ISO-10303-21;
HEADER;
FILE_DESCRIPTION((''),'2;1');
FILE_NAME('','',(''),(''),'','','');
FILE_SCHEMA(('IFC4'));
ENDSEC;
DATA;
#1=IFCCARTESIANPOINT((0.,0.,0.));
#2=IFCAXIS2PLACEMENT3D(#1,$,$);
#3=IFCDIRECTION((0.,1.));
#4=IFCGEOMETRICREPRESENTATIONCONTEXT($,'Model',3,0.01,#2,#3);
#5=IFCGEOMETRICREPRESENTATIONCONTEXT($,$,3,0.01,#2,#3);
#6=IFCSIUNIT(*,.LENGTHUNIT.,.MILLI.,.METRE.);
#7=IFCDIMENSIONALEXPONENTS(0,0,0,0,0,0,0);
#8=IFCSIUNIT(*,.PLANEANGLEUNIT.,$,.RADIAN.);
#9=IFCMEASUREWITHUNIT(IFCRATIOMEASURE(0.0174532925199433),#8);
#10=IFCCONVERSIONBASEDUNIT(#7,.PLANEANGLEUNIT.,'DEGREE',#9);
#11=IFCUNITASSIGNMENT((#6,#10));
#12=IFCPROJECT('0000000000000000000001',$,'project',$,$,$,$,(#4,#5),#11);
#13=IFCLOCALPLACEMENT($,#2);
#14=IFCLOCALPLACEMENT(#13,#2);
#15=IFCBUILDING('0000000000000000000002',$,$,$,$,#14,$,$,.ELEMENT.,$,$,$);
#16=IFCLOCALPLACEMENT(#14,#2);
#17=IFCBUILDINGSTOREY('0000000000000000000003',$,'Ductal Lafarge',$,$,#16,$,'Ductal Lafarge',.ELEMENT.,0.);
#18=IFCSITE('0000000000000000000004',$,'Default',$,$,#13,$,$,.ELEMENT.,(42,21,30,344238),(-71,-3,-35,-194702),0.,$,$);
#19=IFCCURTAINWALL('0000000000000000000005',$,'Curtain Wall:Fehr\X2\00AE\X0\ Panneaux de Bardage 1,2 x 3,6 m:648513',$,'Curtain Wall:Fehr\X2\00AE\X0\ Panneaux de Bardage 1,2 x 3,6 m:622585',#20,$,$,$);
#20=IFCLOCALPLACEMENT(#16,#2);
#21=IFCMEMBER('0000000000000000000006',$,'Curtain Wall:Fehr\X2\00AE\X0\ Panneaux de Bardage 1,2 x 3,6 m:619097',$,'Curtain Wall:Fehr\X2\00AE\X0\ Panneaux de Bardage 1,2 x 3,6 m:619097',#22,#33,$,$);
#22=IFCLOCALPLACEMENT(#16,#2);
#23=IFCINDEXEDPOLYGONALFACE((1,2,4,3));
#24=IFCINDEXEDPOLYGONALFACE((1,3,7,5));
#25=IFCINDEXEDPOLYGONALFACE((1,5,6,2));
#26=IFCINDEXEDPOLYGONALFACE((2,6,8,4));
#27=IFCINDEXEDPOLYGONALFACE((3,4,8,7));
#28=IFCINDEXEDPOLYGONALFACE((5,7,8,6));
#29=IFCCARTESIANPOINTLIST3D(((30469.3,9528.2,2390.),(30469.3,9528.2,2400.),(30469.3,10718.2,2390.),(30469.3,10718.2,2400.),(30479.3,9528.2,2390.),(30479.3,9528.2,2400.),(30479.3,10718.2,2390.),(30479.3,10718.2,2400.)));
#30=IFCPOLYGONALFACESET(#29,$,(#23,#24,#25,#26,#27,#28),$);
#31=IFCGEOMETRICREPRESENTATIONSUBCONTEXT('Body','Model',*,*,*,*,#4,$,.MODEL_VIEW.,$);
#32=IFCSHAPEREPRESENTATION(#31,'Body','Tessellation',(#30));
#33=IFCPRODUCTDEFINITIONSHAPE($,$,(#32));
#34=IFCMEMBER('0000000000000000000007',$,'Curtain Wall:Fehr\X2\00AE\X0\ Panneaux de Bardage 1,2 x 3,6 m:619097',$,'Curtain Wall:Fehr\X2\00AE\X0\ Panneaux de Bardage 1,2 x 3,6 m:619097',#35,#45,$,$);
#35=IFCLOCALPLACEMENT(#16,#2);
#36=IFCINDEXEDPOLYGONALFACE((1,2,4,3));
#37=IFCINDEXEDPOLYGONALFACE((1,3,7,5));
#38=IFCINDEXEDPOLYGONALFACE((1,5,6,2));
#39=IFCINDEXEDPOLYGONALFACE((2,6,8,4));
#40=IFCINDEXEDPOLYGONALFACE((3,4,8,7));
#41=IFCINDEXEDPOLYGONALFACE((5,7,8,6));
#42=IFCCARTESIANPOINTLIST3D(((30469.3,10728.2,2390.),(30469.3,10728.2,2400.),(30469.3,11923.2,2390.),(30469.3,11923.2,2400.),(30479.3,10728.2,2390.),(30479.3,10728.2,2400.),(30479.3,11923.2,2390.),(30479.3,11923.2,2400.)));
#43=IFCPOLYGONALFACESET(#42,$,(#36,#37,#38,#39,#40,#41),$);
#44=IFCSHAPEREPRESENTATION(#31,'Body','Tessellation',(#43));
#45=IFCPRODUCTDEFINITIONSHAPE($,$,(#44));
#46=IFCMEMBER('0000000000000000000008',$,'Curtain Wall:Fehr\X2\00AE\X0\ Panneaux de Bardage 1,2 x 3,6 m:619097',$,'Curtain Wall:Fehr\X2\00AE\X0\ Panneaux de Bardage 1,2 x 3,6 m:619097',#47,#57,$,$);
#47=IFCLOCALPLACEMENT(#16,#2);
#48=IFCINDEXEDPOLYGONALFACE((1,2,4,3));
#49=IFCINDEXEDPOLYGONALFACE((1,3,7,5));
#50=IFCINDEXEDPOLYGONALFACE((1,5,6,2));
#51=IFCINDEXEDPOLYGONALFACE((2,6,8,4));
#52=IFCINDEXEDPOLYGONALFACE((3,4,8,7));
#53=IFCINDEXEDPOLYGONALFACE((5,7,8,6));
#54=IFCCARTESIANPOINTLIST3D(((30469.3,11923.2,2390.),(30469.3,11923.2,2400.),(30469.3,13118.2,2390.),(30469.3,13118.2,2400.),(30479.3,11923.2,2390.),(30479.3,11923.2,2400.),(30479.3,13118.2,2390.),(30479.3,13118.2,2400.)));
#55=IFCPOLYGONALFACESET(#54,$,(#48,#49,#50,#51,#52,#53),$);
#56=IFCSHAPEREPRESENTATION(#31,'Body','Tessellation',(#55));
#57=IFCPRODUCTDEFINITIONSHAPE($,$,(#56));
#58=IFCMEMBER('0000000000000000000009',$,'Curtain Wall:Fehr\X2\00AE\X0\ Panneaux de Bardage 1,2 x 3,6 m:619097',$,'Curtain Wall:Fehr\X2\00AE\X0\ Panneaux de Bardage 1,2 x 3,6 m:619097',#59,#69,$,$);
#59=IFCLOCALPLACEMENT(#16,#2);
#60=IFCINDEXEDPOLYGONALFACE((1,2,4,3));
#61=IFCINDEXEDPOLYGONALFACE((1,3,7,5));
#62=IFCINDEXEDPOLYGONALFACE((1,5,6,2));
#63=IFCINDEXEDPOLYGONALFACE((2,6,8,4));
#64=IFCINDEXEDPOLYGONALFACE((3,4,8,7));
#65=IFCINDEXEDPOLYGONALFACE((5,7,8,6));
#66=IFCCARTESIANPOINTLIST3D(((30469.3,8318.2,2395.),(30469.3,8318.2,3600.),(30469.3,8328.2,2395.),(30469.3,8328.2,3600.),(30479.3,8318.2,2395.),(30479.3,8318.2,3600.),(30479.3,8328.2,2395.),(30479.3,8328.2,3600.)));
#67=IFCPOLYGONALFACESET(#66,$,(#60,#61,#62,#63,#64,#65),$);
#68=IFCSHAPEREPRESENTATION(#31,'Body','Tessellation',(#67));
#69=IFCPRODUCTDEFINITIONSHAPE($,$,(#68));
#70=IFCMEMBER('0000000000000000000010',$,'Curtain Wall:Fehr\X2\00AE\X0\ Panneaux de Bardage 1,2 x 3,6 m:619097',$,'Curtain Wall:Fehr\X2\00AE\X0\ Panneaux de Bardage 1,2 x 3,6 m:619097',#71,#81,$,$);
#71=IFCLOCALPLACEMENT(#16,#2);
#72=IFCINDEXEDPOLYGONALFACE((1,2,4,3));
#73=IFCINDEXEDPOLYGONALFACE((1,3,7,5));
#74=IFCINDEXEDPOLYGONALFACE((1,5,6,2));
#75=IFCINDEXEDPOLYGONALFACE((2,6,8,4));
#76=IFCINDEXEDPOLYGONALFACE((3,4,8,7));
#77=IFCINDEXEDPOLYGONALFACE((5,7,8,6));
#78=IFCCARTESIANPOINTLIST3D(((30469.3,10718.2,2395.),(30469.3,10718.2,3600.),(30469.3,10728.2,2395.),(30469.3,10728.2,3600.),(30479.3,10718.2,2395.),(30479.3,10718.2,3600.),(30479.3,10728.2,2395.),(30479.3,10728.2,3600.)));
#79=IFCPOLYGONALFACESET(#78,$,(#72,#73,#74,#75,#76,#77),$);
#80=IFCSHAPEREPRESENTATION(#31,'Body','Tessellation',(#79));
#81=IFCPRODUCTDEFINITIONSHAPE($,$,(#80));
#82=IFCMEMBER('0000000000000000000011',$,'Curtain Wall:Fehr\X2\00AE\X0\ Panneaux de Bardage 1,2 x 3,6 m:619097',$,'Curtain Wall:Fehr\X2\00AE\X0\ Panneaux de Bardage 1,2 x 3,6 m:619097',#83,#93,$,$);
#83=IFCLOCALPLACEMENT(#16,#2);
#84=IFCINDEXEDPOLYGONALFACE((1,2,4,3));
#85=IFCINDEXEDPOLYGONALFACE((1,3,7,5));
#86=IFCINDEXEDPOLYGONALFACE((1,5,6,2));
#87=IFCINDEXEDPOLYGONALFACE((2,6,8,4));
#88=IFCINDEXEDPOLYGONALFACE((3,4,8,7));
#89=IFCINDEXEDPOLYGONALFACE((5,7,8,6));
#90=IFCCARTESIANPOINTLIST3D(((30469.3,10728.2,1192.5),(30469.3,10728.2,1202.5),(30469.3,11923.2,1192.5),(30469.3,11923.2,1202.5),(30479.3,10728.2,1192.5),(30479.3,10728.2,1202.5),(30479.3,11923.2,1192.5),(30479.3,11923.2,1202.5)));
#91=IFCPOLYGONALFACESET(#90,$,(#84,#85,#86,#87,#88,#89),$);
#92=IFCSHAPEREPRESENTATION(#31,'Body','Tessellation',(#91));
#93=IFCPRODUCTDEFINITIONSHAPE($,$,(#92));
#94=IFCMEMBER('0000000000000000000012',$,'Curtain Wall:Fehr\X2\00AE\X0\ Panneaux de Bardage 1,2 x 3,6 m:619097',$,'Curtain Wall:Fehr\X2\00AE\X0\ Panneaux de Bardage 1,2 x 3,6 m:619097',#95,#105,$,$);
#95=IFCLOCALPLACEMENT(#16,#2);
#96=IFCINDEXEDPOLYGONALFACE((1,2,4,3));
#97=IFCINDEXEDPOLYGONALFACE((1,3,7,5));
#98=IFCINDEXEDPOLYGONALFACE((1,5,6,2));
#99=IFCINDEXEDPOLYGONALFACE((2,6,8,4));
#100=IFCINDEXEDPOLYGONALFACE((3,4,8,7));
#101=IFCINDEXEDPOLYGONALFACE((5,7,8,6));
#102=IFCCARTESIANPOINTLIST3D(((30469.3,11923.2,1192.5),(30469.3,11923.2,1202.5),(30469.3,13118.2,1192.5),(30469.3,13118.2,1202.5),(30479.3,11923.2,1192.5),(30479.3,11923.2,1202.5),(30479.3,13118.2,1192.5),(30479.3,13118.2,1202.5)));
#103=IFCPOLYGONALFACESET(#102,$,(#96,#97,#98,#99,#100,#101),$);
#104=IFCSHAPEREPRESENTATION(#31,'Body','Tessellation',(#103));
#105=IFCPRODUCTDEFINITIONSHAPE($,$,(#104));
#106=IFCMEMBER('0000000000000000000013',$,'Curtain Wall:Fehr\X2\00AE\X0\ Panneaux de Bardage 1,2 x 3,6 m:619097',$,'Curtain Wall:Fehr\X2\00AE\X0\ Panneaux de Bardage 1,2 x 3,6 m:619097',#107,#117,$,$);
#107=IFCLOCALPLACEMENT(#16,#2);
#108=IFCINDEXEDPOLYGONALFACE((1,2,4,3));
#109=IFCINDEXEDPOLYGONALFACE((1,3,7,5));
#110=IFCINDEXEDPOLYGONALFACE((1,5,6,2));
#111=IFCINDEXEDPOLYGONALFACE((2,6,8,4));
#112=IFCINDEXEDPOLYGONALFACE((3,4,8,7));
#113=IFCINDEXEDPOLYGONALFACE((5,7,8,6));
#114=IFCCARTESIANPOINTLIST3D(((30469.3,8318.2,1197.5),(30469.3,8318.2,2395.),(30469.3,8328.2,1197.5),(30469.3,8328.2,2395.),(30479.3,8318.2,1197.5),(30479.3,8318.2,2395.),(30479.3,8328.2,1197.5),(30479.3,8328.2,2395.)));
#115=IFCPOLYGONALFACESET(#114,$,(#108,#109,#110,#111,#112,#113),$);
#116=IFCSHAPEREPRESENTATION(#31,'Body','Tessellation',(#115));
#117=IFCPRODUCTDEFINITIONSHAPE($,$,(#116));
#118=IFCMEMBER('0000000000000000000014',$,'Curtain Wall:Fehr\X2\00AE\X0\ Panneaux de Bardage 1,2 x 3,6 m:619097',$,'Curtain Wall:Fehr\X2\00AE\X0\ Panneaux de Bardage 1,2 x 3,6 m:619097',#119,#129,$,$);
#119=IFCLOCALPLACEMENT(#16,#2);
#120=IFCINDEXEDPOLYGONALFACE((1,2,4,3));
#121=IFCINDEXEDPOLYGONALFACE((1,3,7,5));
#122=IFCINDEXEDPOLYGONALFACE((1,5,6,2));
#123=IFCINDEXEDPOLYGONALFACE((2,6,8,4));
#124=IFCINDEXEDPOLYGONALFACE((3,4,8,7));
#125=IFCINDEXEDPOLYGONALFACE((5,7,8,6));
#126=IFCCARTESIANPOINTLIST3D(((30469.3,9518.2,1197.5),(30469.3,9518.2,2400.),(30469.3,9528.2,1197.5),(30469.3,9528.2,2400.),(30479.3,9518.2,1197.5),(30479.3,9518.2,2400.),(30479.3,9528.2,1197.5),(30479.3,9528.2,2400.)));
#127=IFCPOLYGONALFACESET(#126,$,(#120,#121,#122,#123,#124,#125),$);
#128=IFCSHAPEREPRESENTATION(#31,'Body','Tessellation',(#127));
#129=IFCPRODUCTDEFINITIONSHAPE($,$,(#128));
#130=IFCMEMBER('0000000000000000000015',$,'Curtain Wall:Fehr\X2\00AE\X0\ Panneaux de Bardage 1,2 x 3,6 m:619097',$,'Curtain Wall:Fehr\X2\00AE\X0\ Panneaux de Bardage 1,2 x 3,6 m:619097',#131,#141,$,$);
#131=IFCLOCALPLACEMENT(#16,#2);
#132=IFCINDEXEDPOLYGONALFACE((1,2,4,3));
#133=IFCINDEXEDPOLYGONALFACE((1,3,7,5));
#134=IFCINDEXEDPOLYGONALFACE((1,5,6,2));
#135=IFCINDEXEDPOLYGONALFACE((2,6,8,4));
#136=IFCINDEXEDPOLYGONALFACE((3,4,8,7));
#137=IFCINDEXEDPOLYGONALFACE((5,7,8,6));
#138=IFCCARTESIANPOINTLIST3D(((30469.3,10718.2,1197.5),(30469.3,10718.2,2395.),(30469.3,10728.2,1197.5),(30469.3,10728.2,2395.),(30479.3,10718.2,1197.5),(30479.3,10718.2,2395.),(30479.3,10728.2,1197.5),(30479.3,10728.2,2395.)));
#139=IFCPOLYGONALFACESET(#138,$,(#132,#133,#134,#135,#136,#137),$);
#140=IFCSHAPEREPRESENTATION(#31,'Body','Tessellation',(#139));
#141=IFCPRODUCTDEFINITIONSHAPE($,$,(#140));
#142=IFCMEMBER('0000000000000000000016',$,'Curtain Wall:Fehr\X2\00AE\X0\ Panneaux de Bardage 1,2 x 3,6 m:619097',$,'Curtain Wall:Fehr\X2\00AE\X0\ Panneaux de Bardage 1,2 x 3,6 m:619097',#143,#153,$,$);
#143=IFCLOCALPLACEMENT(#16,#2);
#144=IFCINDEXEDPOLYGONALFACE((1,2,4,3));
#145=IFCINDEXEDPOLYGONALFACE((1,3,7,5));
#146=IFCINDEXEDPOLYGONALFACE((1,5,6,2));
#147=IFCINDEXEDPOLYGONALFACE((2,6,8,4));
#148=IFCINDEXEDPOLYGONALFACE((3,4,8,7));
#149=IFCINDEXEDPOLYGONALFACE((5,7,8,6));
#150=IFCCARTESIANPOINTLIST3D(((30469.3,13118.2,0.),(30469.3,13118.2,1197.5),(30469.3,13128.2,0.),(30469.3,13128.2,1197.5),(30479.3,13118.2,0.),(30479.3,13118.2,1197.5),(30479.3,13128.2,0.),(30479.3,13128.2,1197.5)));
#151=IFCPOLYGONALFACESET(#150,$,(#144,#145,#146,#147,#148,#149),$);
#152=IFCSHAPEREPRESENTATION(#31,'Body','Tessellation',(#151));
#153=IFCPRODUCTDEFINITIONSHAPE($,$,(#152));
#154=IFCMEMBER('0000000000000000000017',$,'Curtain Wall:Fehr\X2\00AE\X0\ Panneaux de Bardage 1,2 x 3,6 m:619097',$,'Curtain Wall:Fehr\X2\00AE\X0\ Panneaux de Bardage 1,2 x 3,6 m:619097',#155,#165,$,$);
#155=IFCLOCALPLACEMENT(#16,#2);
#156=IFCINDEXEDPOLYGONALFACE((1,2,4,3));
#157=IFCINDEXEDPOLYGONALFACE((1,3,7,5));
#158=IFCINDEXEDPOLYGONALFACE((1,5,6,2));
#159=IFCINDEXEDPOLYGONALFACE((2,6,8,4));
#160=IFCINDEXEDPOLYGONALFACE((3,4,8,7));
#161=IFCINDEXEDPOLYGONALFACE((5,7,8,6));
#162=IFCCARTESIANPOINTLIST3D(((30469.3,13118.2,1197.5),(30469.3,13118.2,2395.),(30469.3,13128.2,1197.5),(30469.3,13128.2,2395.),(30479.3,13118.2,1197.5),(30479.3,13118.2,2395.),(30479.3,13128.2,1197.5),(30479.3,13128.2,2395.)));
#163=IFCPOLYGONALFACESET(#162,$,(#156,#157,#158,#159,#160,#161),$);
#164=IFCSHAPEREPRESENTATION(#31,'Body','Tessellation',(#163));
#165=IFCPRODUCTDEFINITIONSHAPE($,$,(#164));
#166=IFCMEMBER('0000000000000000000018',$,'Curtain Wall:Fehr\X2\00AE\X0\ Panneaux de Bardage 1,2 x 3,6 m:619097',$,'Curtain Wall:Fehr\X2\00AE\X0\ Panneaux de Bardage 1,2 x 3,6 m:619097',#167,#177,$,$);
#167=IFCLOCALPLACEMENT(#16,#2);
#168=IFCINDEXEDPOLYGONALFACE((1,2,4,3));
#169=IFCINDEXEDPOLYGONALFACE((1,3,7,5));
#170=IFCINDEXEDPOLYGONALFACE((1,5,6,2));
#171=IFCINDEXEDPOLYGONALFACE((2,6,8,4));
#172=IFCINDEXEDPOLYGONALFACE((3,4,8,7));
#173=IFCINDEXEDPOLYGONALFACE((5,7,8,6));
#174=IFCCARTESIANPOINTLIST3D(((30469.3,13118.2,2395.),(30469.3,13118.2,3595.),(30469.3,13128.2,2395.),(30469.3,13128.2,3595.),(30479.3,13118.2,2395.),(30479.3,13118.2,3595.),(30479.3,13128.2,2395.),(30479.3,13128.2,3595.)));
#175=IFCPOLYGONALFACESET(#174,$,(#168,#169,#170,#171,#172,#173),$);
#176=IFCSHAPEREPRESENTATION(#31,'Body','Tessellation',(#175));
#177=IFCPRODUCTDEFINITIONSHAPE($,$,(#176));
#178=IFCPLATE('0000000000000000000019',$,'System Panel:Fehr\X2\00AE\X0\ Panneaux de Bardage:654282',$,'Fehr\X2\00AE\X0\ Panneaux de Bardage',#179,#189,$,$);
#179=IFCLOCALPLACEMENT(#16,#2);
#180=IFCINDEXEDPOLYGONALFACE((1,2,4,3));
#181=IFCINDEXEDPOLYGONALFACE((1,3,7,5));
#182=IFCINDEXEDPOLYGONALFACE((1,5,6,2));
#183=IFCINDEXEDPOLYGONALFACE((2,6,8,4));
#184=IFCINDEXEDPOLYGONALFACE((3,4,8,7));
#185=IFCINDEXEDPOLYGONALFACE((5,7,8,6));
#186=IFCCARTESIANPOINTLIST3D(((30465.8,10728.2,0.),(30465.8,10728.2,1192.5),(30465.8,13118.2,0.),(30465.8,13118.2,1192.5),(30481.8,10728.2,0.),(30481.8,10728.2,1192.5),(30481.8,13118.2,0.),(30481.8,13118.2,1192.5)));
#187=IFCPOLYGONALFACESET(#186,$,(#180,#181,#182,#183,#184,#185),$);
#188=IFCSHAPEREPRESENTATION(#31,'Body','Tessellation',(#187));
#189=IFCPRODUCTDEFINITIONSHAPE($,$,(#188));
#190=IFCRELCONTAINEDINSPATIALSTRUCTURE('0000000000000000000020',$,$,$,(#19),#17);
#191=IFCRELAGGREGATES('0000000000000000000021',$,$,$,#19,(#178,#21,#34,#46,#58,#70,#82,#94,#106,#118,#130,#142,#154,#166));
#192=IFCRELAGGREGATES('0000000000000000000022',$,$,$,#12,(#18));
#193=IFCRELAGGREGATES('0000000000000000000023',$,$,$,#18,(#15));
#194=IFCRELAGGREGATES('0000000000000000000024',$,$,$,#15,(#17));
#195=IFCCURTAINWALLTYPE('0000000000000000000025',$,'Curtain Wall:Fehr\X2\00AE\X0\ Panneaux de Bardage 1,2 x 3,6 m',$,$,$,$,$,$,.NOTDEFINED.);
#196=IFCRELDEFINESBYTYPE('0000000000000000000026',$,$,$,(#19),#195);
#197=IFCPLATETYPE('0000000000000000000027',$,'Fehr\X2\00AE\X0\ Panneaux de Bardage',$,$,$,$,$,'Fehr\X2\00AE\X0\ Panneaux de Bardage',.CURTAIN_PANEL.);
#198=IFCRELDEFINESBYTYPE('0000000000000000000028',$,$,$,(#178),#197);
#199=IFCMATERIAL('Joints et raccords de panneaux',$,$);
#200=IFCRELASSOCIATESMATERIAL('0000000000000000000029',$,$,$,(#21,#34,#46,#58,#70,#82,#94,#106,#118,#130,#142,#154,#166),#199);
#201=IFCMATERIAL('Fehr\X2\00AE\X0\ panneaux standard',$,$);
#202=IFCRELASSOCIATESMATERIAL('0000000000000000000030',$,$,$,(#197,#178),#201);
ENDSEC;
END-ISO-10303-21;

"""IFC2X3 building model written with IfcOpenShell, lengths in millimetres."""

from ifc_helpers import new_model, entity, si_unit, converted_unit, direction, frame, frame_2d, origin, place, context, subcontext, project, spatial, rectangle, extrude, source, transform, mapped, material, type_object, type_shapes, element, aggregate, save


model = new_model("IFC2X3")

# Units and contexts
model_context = context("Model", 3, precision=0.01, world=origin(), true_north=direction((0.0, 1.0)))
context_of_model = context(None, 3, precision=0.01, world=origin(), true_north=direction((0.0, 1.0)))
body_context = subcontext(model_context, "Body", "Model", "MODEL_VIEW")
ifc_project = project(units=[si_unit("LENGTHUNIT", "METRE", prefix="MILLI"), converted_unit("PLANEANGLEUNIT", "DEGREE", entity("IfcRatioMeasure", 0.0174532925199433), si_unit("PLANEANGLEUNIT", "RADIAN"), dimensions=[0, 0, 0, 0, 0, 0, 0])], contexts=[model_context, context_of_model])

# Site, building, storey
site_placement = place(None, origin())
site = spatial("IfcSite", under=ifc_project, at=site_placement, Name="Default", CompositionType="ELEMENT", RefLatitude=(42, 21, 30, 344238), RefLongitude=(-71, -3, -35, -194702), RefElevation=0.0)
building_placement = place(site_placement, origin())
building = spatial("IfcBuilding", under=site, at=building_placement, CompositionType="ELEMENT")
storey_placement = place(building_placement, origin())
storey = spatial("IfcBuildingStorey", under=building, at=storey_placement, Name="Ductal Lafarge", LongName="Ductal Lafarge", CompositionType="ELEMENT", Elevation=0.0)

# Curtain wall, members, plate
curtain_wall_type = type_object("IfcCurtainWallType", Name="Curtain Wall:Fehr® Panneaux de Bardage 1,2 x 3,6 m", PredefinedType="NOTDEFINED")
curtain_wall_placement = place(storey_placement, origin())
curtain_wall = element("IfcCurtainWall", 1, at=curtain_wall_placement, inside=storey, type_object=curtain_wall_type, Name="Curtain Wall:Fehr® Panneaux de Bardage 1,2 x 3,6 m:648513", ObjectType="Curtain Wall:Fehr® Panneaux de Bardage 1,2 x 3,6 m:622585")
ifc_material_1 = material(Name="Joints et raccords de panneaux")
member_1_placement = place(curtain_wall_placement, frame((30469.3, 9528.2, 2390.0)))
member_1 = element("IfcMember", 2, at=member_1_placement, material=ifc_material_1, Name="Curtain Wall:Fehr® Panneaux de Bardage 1,2 x 3,6 m:619097", ObjectType="Curtain Wall:Fehr® Panneaux de Bardage 1,2 x 3,6 m:619097", context=body_context, shape_type="SweptSolid", body=[
    extrude(rectangle(XDim=1190.0, YDim=10.0, at=frame_2d((0.0, 0.0), x_axis=(1.0, 0.0))), frame((5.0, 595.0, 0.0), z_axis=(0.0, 0.0, 1.0), x_axis=(0.0, -1.0, 0.0)), (0.0, 0.0, 1.0), 10.0),
])
member_2_placement = place(curtain_wall_placement, frame((30469.3, 10728.2, 2390.0)))
member_2 = element("IfcMember", 3, at=member_2_placement, material=ifc_material_1, Name="Curtain Wall:Fehr® Panneaux de Bardage 1,2 x 3,6 m:619097", ObjectType="Curtain Wall:Fehr® Panneaux de Bardage 1,2 x 3,6 m:619097", context=body_context, shape_type="SweptSolid", body=[
    extrude(rectangle(XDim=1195.0, YDim=10.0, at=frame_2d((0.0, 0.0), x_axis=(1.0, 0.0))), frame((5.0, 597.5, 0.0), z_axis=(0.0, 0.0, 1.0), x_axis=(0.0, -1.0, 0.0)), (0.0, 0.0, 1.0), 10.0),
])
member_3_placement = place(curtain_wall_placement, frame((30469.3, 11923.2, 2390.0)))
member_3 = element("IfcMember", 4, at=member_3_placement, material=ifc_material_1, Name="Curtain Wall:Fehr® Panneaux de Bardage 1,2 x 3,6 m:619097", ObjectType="Curtain Wall:Fehr® Panneaux de Bardage 1,2 x 3,6 m:619097", context=body_context, shape_type="SweptSolid", body=[
    extrude(rectangle(XDim=1195.0, YDim=10.0, at=frame_2d((0.0, 0.0), x_axis=(1.0, 0.0))), frame((5.0, 597.5, 0.0), z_axis=(0.0, 0.0, 1.0), x_axis=(0.0, -1.0, 0.0)), (0.0, 0.0, 1.0), 10.0),
])
member_4_placement = place(curtain_wall_placement, frame((30469.3, 8318.2, 2395.0)))
member_4 = element("IfcMember", 5, at=member_4_placement, material=ifc_material_1, Name="Curtain Wall:Fehr® Panneaux de Bardage 1,2 x 3,6 m:619097", ObjectType="Curtain Wall:Fehr® Panneaux de Bardage 1,2 x 3,6 m:619097", context=body_context, shape_type="SweptSolid", body=[
    extrude(rectangle(XDim=10.0, YDim=10.0, at=frame_2d((0.0, 0.0), x_axis=(1.0, 0.0))), frame((5.0, 5.0, 0.0), z_axis=(0.0, 0.0, 1.0), x_axis=(-1.0, 0.0, 0.0)), (0.0, 0.0, 1.0), 1205.0),
])
member_5_placement = place(curtain_wall_placement, frame((30469.3, 10718.2, 2395.0)))
member_5 = element("IfcMember", 6, at=member_5_placement, material=ifc_material_1, Name="Curtain Wall:Fehr® Panneaux de Bardage 1,2 x 3,6 m:619097", ObjectType="Curtain Wall:Fehr® Panneaux de Bardage 1,2 x 3,6 m:619097", context=body_context, shape_type="SweptSolid", body=[
    extrude(rectangle(XDim=10.0, YDim=10.0, at=frame_2d((0.0, 0.0), x_axis=(1.0, 0.0))), frame((5.0, 5.0, 0.0), z_axis=(0.0, 0.0, 1.0), x_axis=(-1.0, 0.0, 0.0)), (0.0, 0.0, 1.0), 1205.0),
])
member_6_placement = place(curtain_wall_placement, frame((30469.3, 10728.2, 1192.5)))
member_6 = element("IfcMember", 7, at=member_6_placement, material=ifc_material_1, Name="Curtain Wall:Fehr® Panneaux de Bardage 1,2 x 3,6 m:619097", ObjectType="Curtain Wall:Fehr® Panneaux de Bardage 1,2 x 3,6 m:619097", context=body_context, shape_type="SweptSolid", body=[
    extrude(rectangle(XDim=1195.0, YDim=10.0, at=frame_2d((0.0, 0.0), x_axis=(1.0, 0.0))), frame((5.0, 597.5, 0.0), z_axis=(0.0, 0.0, 1.0), x_axis=(0.0, -1.0, 0.0)), (0.0, 0.0, 1.0), 10.0),
])
member_7_placement = place(curtain_wall_placement, frame((30469.3, 11923.2, 1192.5)))
member_7 = element("IfcMember", 8, at=member_7_placement, material=ifc_material_1, Name="Curtain Wall:Fehr® Panneaux de Bardage 1,2 x 3,6 m:619097", ObjectType="Curtain Wall:Fehr® Panneaux de Bardage 1,2 x 3,6 m:619097", context=body_context, shape_type="SweptSolid", body=[
    extrude(rectangle(XDim=1195.0, YDim=10.0, at=frame_2d((0.0, 0.0), x_axis=(1.0, 0.0))), frame((5.0, 597.5, 0.0), z_axis=(0.0, 0.0, 1.0), x_axis=(0.0, -1.0, 0.0)), (0.0, 0.0, 1.0), 10.0),
])
member_8_placement = place(curtain_wall_placement, frame((30469.3, 8318.2, 1197.5)))
member_8 = element("IfcMember", 9, at=member_8_placement, material=ifc_material_1, Name="Curtain Wall:Fehr® Panneaux de Bardage 1,2 x 3,6 m:619097", ObjectType="Curtain Wall:Fehr® Panneaux de Bardage 1,2 x 3,6 m:619097", context=body_context, shape_type="SweptSolid", body=[
    extrude(rectangle(XDim=10.0, YDim=10.0, at=frame_2d((0.0, 0.0), x_axis=(1.0, 0.0))), frame((5.0, 5.0, 0.0), z_axis=(0.0, 0.0, 1.0), x_axis=(-1.0, 0.0, 0.0)), (0.0, 0.0, 1.0), 1197.5),
])
member_9_placement = place(curtain_wall_placement, frame((30469.3, 9518.2, 1197.5)))
member_9 = element("IfcMember", 10, at=member_9_placement, material=ifc_material_1, Name="Curtain Wall:Fehr® Panneaux de Bardage 1,2 x 3,6 m:619097", ObjectType="Curtain Wall:Fehr® Panneaux de Bardage 1,2 x 3,6 m:619097", context=body_context, shape_type="SweptSolid", body=[
    extrude(rectangle(XDim=10.0, YDim=10.0, at=frame_2d((0.0, 0.0), x_axis=(1.0, 0.0))), frame((5.0, 5.0, 0.0), z_axis=(0.0, 0.0, 1.0), x_axis=(-1.0, 0.0, 0.0)), (0.0, 0.0, 1.0), 1202.5),
])
member_10_placement = place(curtain_wall_placement, frame((30469.3, 10718.2, 1197.5)))
member_10 = element("IfcMember", 11, at=member_10_placement, material=ifc_material_1, Name="Curtain Wall:Fehr® Panneaux de Bardage 1,2 x 3,6 m:619097", ObjectType="Curtain Wall:Fehr® Panneaux de Bardage 1,2 x 3,6 m:619097", context=body_context, shape_type="SweptSolid", body=[
    extrude(rectangle(XDim=10.0, YDim=10.0, at=frame_2d((0.0, 0.0), x_axis=(1.0, 0.0))), frame((5.0, 5.0, 0.0), z_axis=(0.0, 0.0, 1.0), x_axis=(-1.0, 0.0, 0.0)), (0.0, 0.0, 1.0), 1197.5),
])
member_11_placement = place(curtain_wall_placement, frame((30469.3, 13118.2, 0.0)))
member_11 = element("IfcMember", 12, at=member_11_placement, material=ifc_material_1, Name="Curtain Wall:Fehr® Panneaux de Bardage 1,2 x 3,6 m:619097", ObjectType="Curtain Wall:Fehr® Panneaux de Bardage 1,2 x 3,6 m:619097", context=body_context, shape_type="SweptSolid", body=[
    extrude(rectangle(XDim=10.0, YDim=10.0, at=frame_2d((0.0, 0.0), x_axis=(1.0, 0.0))), frame((5.0, 5.0, 0.0), z_axis=(0.0, 0.0, 1.0), x_axis=(-1.0, 0.0, 0.0)), (0.0, 0.0, 1.0), 1197.5),
])
member_12_placement = place(curtain_wall_placement, frame((30469.3, 13118.2, 1197.5)))
member_12 = element("IfcMember", 13, at=member_12_placement, material=ifc_material_1, Name="Curtain Wall:Fehr® Panneaux de Bardage 1,2 x 3,6 m:619097", ObjectType="Curtain Wall:Fehr® Panneaux de Bardage 1,2 x 3,6 m:619097", context=body_context, shape_type="SweptSolid", body=[
    extrude(rectangle(XDim=10.0, YDim=10.0, at=frame_2d((0.0, 0.0), x_axis=(1.0, 0.0))), frame((5.0, 5.0, 0.0), z_axis=(0.0, 0.0, 1.0), x_axis=(-1.0, 0.0, 0.0)), (0.0, 0.0, 1.0), 1197.5),
])
member_13_placement = place(curtain_wall_placement, frame((30469.3, 13118.2, 2395.0)))
member_13 = element("IfcMember", 14, at=member_13_placement, material=ifc_material_1, Name="Curtain Wall:Fehr® Panneaux de Bardage 1,2 x 3,6 m:619097", ObjectType="Curtain Wall:Fehr® Panneaux de Bardage 1,2 x 3,6 m:619097", context=body_context, shape_type="SweptSolid", body=[
    extrude(rectangle(XDim=10.0, YDim=10.0, at=frame_2d((0.0, 0.0), x_axis=(1.0, 0.0))), frame((5.0, 5.0, 0.0), z_axis=(0.0, 0.0, 1.0), x_axis=(-1.0, 0.0, 0.0)), (0.0, 0.0, 1.0), 1200.0),
])
ifc_material_2 = material(Name="Fehr® panneaux standard")
plate_type_1 = type_object("IfcPlateType", Name="Fehr® Panneaux de Bardage", ElementType="Fehr® Panneaux de Bardage", PredefinedType="CURTAIN_PANEL", material=ifc_material_2)
shared_shape_1 = source(origin(), body_context, "Body", "SweptSolid", [
    extrude(rectangle(XDim=1192.5, YDim=2390.0, at=frame_2d((0.0, 0.0), x_axis=(1.0, 0.0))), frame((0.0, -8.0, 596.2), z_axis=(0.0, 1.0, 0.0), x_axis=(0.0, 0.0, 1.0)), (0.0, 0.0, 1.0), 16.0),
])
type_shapes(plate_type_1, [shared_shape_1])
plate_1_placement = place(curtain_wall_placement, frame((30473.8, 11923.2, 0.0), z_axis=(0.0, 0.0, 1.0), x_axis=(0.0, 1.0, 0.0)))
plate_1 = element("IfcPlate", 15, at=plate_1_placement, type_object=plate_type_1, material=ifc_material_2, Name="System Panel:Fehr® Panneaux de Bardage:654282", ObjectType="Fehr® Panneaux de Bardage", context=body_context, shape_type="MappedRepresentation", body=[
    mapped(shared_shape_1, transform((0.0, 0.0, 0.0), scale=1.0)),
])
aggregate(curtain_wall, [plate_1, member_1, member_2, member_3, member_4, member_5, member_6, member_7, member_8, member_9, member_10, member_11, member_12, member_13])

save(model, "model.ifc")
